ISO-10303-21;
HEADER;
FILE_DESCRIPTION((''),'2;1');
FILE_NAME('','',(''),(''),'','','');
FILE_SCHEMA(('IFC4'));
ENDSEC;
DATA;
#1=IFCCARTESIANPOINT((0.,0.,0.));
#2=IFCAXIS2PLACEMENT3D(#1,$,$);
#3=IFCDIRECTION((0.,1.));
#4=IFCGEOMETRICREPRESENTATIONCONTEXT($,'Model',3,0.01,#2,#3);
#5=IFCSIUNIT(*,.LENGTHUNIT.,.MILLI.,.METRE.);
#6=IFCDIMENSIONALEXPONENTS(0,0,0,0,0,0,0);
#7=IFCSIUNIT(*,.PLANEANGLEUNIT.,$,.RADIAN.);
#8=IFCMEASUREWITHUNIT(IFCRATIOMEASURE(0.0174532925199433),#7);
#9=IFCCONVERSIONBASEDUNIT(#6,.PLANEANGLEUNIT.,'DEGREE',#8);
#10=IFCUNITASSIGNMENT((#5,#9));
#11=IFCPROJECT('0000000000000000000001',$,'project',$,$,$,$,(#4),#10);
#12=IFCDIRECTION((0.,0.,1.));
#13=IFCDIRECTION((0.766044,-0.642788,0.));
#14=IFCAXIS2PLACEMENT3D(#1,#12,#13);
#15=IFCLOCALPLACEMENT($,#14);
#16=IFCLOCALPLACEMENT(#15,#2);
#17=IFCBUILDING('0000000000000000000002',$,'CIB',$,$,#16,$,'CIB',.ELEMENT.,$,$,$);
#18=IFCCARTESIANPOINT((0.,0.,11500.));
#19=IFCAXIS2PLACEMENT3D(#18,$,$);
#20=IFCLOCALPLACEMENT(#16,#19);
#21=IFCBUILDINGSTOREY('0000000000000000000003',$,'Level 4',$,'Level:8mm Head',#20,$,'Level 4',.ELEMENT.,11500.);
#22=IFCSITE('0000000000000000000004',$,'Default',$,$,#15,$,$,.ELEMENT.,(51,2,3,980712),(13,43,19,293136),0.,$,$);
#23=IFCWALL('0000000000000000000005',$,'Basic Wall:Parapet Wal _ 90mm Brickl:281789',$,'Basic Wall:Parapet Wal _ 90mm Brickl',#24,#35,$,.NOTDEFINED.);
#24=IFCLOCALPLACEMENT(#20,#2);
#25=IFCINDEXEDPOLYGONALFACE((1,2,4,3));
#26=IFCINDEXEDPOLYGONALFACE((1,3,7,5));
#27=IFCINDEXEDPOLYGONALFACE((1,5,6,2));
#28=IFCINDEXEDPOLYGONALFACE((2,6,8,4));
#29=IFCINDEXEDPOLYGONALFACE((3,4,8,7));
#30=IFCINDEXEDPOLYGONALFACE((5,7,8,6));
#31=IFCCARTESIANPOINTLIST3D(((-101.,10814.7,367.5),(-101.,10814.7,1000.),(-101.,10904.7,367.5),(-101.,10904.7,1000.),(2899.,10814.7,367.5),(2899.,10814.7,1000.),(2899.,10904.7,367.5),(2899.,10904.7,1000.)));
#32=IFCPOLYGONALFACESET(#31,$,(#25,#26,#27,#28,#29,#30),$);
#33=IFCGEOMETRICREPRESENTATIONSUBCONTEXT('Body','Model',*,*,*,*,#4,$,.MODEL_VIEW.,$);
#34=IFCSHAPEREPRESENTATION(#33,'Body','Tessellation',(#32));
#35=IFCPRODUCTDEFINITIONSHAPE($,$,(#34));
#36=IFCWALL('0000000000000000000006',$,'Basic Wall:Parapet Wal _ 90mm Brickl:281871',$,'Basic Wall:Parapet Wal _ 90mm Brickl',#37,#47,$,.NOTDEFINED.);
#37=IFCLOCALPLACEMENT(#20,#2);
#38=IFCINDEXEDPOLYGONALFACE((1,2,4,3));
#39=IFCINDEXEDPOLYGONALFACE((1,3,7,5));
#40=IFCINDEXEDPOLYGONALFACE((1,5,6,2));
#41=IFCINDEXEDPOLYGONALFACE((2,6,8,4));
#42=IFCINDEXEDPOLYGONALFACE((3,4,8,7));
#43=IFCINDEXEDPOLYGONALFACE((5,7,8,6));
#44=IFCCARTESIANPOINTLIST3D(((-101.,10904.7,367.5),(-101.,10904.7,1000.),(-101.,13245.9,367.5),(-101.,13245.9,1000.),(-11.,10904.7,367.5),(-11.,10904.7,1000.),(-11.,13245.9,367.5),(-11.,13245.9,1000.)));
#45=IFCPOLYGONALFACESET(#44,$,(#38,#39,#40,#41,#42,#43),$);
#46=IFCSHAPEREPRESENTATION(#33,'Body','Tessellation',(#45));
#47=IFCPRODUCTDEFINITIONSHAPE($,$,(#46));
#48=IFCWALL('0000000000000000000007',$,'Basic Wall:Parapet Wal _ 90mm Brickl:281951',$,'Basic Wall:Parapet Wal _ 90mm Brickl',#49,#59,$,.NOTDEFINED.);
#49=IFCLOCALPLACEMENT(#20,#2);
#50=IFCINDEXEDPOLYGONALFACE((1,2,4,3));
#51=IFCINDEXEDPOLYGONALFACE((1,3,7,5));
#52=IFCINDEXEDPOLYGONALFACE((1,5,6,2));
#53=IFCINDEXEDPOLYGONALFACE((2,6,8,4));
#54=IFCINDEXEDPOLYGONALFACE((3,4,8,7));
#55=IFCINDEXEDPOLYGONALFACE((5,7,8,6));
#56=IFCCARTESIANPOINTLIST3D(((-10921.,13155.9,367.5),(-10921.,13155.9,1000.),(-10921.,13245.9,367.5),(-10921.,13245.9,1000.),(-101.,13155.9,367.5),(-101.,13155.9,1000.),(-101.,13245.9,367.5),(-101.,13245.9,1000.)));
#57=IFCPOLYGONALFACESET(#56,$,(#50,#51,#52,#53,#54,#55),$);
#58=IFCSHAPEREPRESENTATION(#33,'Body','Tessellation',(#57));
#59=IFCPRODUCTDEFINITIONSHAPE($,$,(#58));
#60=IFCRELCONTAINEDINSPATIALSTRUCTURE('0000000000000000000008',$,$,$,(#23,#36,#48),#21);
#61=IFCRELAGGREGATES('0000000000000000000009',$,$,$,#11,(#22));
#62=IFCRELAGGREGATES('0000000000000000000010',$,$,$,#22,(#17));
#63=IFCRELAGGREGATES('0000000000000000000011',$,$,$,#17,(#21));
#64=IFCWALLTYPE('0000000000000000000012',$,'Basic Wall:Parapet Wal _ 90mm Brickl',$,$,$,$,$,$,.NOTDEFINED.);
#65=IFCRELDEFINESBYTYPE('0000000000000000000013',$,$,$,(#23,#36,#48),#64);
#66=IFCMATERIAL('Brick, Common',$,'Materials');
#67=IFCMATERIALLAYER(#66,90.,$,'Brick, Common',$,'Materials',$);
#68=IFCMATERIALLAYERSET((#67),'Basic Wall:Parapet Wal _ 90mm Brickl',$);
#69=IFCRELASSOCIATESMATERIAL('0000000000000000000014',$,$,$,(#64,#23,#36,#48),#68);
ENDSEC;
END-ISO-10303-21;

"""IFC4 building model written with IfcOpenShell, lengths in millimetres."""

from ifc_helpers import new_model, entity, si_unit, converted_unit, direction, frame, frame_2d, origin, place, context, subcontext, project, spatial, rectangle, extrude, material, layer, layer_set, layer_usage, type_object, element, save


model = new_model("IFC4")

# Units and contexts
model_context = context("Model", 3, precision=0.01, world=origin(), true_north=direction((0.0, 1.0)))
body_context = subcontext(model_context, "Body", "Model", "MODEL_VIEW")
ifc_project = project(units=[si_unit("LENGTHUNIT", "METRE", prefix="MILLI"), converted_unit("PLANEANGLEUNIT", "DEGREE", entity("IfcRatioMeasure", 0.0174532925199433), si_unit("PLANEANGLEUNIT", "RADIAN"), dimensions=[0, 0, 0, 0, 0, 0, 0])], contexts=[model_context])

# Site, building, storey
site_placement = place(None, frame((0.0, 0.0, 0.0), z_axis=(0.0, 0.0, 1.0), x_axis=(0.766044, -0.642788, 0.0)))
site = spatial("IfcSite", under=ifc_project, at=site_placement, Name="Default", CompositionType="ELEMENT", RefLatitude=(51, 2, 3, 980712), RefLongitude=(13, 43, 19, 293136), RefElevation=0.0)
building_placement = place(site_placement, origin())
building = spatial("IfcBuilding", under=site, at=building_placement, Name="CIB", LongName="CIB", CompositionType="ELEMENT")
storey_placement = place(building_placement, frame((0.0, 0.0, 11500.0)))
storey = spatial("IfcBuildingStorey", under=building, at=storey_placement, Name="Level 4", ObjectType="Level:8mm Head", LongName="Level 4", CompositionType="ELEMENT", Elevation=11500.0)

# Shared definitions
ifc_material_1 = material(Name="Brick, Common", Category="Materials")

# Walls
ifc_layer_1 = layer(ifc_material_1, 90.0, Name="Brick, Common", Category="Materials")
ifc_layer_set_1 = layer_set([ifc_layer_1], Name="Basic Wall:Parapet Wal _ 90mm Brickl")
wall_type_1 = type_object("IfcWallType", Name="Basic Wall:Parapet Wal _ 90mm Brickl", PredefinedType="NOTDEFINED", material=ifc_layer_set_1)
ifc_layer_usage_1 = layer_usage(ifc_layer_set_1, "AXIS2", "NEGATIVE", 45.0)
wall_1_placement = place(storey_placement, frame((2899.0, 10859.7, 367.5), z_axis=(0.0, 0.0, 1.0), x_axis=(-1.0, 0.0, 0.0)))
element("IfcWall", 1, at=wall_1_placement, inside=storey, type_object=wall_type_1, material=ifc_layer_usage_1, Name="Basic Wall:Parapet Wal _ 90mm Brickl:281789", ObjectType="Basic Wall:Parapet Wal _ 90mm Brickl", PredefinedType="NOTDEFINED", context=body_context, shape_type="SweptSolid", body=[
    extrude(rectangle(XDim=3000.0, YDim=90.0, at=frame_2d((1500.0, 0.0), x_axis=(-1.0, 0.0))), origin(), (0.0, 0.0, 1.0), 632.5),
])
ifc_layer_usage_2 = layer_usage(ifc_layer_set_1, "AXIS2", "NEGATIVE", 45.0)
wall_2_placement = place(storey_placement, frame((-56.0, 10904.7, 367.5), z_axis=(0.0, 0.0, 1.0), x_axis=(0.0, 1.0, 0.0)))
element("IfcWall", 2, at=wall_2_placement, inside=storey, type_object=wall_type_1, material=ifc_layer_usage_2, Name="Basic Wall:Parapet Wal _ 90mm Brickl:281871", ObjectType="Basic Wall:Parapet Wal _ 90mm Brickl", PredefinedType="NOTDEFINED", context=body_context, shape_type="SweptSolid", body=[
    extrude(rectangle(XDim=2341.3, YDim=90.0, at=frame_2d((1170.6, 0.0), x_axis=(-1.0, 0.0))), origin(), (0.0, 0.0, 1.0), 632.5),
])
ifc_layer_usage_3 = layer_usage(ifc_layer_set_1, "AXIS2", "NEGATIVE", 45.0)
wall_3_placement = place(storey_placement, frame((-101.0, 13200.9, 367.5), z_axis=(0.0, 0.0, 1.0), x_axis=(-1.0, 0.0, 0.0)))
element("IfcWall", 3, at=wall_3_placement, inside=storey, type_object=wall_type_1, material=ifc_layer_usage_3, Name="Basic Wall:Parapet Wal _ 90mm Brickl:281951", ObjectType="Basic Wall:Parapet Wal _ 90mm Brickl", PredefinedType="NOTDEFINED", context=body_context, shape_type="SweptSolid", body=[
    extrude(rectangle(XDim=10820.0, YDim=90.0, at=frame_2d((5410.0, 0.0), x_axis=(-1.0, 0.0))), origin(), (0.0, 0.0, 1.0), 632.5),
])

save(model, "model.ifc")
